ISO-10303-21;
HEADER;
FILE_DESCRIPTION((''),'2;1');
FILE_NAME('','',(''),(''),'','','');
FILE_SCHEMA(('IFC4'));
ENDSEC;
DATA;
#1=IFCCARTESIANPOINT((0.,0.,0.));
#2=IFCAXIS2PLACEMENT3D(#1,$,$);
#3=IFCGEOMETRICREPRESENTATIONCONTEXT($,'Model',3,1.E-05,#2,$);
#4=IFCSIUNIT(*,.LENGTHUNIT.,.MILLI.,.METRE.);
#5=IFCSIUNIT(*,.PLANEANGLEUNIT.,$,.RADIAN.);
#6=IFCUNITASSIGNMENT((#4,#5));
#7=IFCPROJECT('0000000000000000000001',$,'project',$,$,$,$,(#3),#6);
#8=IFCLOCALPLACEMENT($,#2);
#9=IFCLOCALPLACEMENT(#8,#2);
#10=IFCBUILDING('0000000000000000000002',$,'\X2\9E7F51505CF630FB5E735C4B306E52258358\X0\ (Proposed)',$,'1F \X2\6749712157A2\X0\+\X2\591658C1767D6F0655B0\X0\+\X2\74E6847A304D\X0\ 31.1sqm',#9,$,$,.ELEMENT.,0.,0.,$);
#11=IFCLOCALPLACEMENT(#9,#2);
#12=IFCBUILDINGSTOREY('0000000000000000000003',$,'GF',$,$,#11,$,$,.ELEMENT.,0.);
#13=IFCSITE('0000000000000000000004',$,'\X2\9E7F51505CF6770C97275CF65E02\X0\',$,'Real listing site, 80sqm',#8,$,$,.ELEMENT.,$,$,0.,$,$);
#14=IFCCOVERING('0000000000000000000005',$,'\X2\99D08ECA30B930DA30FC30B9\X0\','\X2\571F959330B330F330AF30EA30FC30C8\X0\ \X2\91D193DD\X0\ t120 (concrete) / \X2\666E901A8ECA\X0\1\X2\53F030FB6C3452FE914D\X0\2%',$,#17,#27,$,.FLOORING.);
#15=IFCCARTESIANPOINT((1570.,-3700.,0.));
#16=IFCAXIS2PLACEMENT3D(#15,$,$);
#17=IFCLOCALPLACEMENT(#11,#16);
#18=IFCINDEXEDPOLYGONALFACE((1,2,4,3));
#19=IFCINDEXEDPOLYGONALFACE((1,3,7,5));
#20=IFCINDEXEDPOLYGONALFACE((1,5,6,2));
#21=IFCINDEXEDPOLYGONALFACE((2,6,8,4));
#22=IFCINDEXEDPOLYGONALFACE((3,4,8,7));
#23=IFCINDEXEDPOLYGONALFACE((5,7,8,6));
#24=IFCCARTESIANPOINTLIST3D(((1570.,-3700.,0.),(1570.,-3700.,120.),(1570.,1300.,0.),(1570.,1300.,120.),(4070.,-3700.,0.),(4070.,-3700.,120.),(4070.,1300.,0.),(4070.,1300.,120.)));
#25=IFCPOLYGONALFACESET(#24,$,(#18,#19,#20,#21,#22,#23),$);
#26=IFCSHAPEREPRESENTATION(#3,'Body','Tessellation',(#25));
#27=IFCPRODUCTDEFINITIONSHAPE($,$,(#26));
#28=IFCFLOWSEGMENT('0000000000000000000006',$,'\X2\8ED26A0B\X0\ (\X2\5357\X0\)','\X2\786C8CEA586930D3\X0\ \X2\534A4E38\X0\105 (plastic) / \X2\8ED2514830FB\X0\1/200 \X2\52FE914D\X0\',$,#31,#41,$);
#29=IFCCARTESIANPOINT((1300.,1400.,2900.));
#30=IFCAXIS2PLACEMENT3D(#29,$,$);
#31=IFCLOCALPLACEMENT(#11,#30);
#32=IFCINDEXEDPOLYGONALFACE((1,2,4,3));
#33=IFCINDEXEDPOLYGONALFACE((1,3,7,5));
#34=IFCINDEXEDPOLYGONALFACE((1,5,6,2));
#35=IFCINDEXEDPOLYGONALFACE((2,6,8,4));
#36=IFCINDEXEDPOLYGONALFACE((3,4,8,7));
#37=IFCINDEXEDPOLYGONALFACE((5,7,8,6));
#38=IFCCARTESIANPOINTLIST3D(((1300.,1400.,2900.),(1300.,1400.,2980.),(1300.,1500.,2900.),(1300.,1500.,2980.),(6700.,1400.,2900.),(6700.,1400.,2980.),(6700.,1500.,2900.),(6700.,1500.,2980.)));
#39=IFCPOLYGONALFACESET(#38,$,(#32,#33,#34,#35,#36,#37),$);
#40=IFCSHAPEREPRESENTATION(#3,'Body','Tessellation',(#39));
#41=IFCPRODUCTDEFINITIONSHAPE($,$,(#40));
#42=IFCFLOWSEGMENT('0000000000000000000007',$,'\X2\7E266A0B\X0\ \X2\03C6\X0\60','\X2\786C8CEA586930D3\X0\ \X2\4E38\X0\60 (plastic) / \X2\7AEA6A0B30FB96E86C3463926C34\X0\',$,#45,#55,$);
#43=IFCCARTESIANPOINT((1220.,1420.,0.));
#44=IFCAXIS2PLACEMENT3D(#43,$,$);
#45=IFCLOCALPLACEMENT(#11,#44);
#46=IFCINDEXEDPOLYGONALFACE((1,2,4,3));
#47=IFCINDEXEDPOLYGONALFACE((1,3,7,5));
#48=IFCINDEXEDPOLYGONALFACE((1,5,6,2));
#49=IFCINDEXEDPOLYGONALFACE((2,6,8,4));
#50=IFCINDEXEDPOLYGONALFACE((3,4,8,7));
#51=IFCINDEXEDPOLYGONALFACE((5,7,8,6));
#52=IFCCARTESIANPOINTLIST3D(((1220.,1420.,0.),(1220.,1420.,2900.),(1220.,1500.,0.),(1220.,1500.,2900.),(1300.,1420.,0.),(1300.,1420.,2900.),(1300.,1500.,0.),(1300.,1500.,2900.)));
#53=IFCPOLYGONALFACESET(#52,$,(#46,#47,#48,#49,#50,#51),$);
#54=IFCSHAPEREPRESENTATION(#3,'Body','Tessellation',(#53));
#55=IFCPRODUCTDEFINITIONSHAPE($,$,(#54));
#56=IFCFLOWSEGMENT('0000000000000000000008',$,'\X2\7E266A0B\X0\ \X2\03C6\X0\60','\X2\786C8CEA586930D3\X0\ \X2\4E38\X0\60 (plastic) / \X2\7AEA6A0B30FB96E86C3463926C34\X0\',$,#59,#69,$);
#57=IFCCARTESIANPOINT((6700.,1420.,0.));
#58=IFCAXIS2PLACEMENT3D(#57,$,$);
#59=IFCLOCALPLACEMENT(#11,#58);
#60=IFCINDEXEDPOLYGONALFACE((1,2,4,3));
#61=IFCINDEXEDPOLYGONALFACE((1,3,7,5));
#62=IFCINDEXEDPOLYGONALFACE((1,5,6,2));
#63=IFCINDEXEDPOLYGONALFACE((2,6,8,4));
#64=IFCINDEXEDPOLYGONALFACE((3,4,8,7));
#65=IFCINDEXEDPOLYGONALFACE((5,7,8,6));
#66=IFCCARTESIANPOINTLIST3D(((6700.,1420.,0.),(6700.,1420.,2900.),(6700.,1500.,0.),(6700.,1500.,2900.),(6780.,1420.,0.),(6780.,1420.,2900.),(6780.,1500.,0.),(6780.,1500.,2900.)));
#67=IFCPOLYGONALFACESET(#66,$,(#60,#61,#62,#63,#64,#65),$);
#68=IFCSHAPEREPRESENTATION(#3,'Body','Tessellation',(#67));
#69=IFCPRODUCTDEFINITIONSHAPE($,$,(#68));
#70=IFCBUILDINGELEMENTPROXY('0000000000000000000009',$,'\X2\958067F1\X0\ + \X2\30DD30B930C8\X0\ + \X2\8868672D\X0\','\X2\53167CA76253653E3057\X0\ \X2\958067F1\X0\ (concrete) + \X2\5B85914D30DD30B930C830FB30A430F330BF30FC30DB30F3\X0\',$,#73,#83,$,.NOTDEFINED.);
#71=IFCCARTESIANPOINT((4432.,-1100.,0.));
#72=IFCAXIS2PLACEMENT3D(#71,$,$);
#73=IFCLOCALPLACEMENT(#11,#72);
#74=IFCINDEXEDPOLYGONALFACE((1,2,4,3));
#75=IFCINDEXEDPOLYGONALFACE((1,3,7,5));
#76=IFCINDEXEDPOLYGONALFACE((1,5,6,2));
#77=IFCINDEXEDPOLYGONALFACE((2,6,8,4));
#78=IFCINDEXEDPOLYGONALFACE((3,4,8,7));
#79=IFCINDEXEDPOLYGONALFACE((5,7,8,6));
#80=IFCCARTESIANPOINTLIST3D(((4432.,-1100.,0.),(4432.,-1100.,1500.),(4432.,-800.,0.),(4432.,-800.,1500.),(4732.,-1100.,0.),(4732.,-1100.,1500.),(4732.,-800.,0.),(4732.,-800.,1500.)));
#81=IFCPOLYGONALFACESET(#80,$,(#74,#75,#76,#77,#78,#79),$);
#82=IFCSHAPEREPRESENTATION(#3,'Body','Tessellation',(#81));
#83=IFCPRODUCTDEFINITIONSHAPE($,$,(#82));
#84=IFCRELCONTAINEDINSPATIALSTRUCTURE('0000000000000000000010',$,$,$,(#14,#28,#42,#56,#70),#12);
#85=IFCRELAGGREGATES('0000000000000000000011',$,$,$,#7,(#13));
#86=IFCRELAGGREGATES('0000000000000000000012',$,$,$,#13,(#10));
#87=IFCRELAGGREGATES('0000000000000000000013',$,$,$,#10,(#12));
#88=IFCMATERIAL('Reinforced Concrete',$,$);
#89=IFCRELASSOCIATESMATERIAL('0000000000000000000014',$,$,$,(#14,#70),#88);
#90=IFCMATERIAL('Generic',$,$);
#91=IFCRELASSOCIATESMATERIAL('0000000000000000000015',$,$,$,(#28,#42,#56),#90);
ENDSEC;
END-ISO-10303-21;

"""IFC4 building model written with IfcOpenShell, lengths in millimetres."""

from ifc_helpers import new_model, si_unit, frame, frame_2d, origin, place, context, project, spatial, rectangle, extrude, material, element, save


model = new_model("IFC4")

# Units and contexts
model_context = context("Model", 3, precision=1e-05, world=origin())
ifc_project = project(units=[si_unit("LENGTHUNIT", "METRE", prefix="MILLI"), si_unit("PLANEANGLEUNIT", "RADIAN")], contexts=[model_context])

# Site, building, storey
site_placement = place(None, origin())
site = spatial("IfcSite", under=ifc_project, at=site_placement, Name="鹿児島県霧島市", ObjectType="Real listing site, 80sqm", CompositionType="ELEMENT", RefElevation=0.0)
building_placement = place(site_placement, origin())
building = spatial("IfcBuilding", under=site, at=building_placement, Name="鹿児島・平屋の別荘 (Proposed)", ObjectType="1F 杉無垢+外壁白漆喰+瓦葺き 31.1sqm", CompositionType="ELEMENT", ElevationOfRefHeight=0.0, ElevationOfTerrain=0.0)
storey_placement = place(building_placement, origin())
storey = spatial("IfcBuildingStorey", under=building, at=storey_placement, Name="GF", CompositionType="ELEMENT", Elevation=0.0)

# Shared definitions
ifc_material_1 = material(Name="Reinforced Concrete")

# Covering
ifc_material_2 = material(Name="Generic")
covering_1_placement = place(storey_placement, frame((1570.0, -3700.0, 0.0)))
element("IfcCovering", 1, at=covering_1_placement, inside=storey, material=ifc_material_1, Name="駐車スペース", Description="土間コンクリート 金鏝 t120 (concrete) / 普通車1台・水勾配2%", PredefinedType="FLOORING", context=model_context, shape_type="SweptSolid", body=[
    extrude(rectangle(XDim=2500.0, YDim=5000.0, at=frame_2d((1250.0, 2500.0))), frame((1570.0, -3700.0, 0.0)), (0.0, 0.0, 1.0), 120.0),
])

# Flow segments
flow_segment_1_placement = place(storey_placement, frame((1300.0, 1400.0, 2900.0)))
element("IfcFlowSegment", 2, at=flow_segment_1_placement, inside=storey, material=ifc_material_2, Name="軒樋 (南)", Description="硬質塩ビ 半丸105 (plastic) / 軒先・1/200 勾配", context=model_context, shape_type="SweptSolid", body=[
    extrude(rectangle(XDim=5400.0, YDim=100.0, at=frame_2d((2700.0, 50.0))), frame((1300.0, 1400.0, 2900.0)), (0.0, 0.0, 1.0), 80.0),
])
flow_segment_2_placement = place(storey_placement, frame((1220.0, 1420.0, 0.0)))
element("IfcFlowSegment", 3, at=flow_segment_2_placement, inside=storey, material=ifc_material_2, Name="縦樋 φ60", Description="硬質塩ビ 丸60 (plastic) / 竪樋・雨水排水", context=model_context, shape_type="SweptSolid", body=[
    extrude(rectangle(XDim=80.0, YDim=80.0, at=frame_2d((40.0, 40.0))), frame((1220.0, 1420.0, 0.0)), (0.0, 0.0, 1.0), 2900.0),
])
flow_segment_3_placement = place(storey_placement, frame((6700.0, 1420.0, 0.0)))
element("IfcFlowSegment", 4, at=flow_segment_3_placement, inside=storey, material=ifc_material_2, Name="縦樋 φ60", Description="硬質塩ビ 丸60 (plastic) / 竪樋・雨水排水", context=model_context, shape_type="SweptSolid", body=[
    extrude(rectangle(XDim=80.0, YDim=80.0, at=frame_2d((40.0, 40.0))), frame((6700.0, 1420.0, 0.0)), (0.0, 0.0, 1.0), 2900.0),
])

# Building element proxy
proxy_placement = place(storey_placement, frame((4432.0, -1100.0, 0.0)))
element("IfcBuildingElementProxy", 5, at=proxy_placement, inside=storey, material=ifc_material_1, Name="門柱 + ポスト + 表札", Description="化粧打放し 門柱 (concrete) + 宅配ポスト・インターホン", PredefinedType="NOTDEFINED", context=model_context, shape_type="SweptSolid", body=[
    extrude(rectangle(XDim=300.0, YDim=300.0, at=frame_2d((150.0, 150.0))), frame((4432.0, -1100.0, 0.0)), (0.0, 0.0, 1.0), 1500.0),
])

save(model, "model.ifc")
